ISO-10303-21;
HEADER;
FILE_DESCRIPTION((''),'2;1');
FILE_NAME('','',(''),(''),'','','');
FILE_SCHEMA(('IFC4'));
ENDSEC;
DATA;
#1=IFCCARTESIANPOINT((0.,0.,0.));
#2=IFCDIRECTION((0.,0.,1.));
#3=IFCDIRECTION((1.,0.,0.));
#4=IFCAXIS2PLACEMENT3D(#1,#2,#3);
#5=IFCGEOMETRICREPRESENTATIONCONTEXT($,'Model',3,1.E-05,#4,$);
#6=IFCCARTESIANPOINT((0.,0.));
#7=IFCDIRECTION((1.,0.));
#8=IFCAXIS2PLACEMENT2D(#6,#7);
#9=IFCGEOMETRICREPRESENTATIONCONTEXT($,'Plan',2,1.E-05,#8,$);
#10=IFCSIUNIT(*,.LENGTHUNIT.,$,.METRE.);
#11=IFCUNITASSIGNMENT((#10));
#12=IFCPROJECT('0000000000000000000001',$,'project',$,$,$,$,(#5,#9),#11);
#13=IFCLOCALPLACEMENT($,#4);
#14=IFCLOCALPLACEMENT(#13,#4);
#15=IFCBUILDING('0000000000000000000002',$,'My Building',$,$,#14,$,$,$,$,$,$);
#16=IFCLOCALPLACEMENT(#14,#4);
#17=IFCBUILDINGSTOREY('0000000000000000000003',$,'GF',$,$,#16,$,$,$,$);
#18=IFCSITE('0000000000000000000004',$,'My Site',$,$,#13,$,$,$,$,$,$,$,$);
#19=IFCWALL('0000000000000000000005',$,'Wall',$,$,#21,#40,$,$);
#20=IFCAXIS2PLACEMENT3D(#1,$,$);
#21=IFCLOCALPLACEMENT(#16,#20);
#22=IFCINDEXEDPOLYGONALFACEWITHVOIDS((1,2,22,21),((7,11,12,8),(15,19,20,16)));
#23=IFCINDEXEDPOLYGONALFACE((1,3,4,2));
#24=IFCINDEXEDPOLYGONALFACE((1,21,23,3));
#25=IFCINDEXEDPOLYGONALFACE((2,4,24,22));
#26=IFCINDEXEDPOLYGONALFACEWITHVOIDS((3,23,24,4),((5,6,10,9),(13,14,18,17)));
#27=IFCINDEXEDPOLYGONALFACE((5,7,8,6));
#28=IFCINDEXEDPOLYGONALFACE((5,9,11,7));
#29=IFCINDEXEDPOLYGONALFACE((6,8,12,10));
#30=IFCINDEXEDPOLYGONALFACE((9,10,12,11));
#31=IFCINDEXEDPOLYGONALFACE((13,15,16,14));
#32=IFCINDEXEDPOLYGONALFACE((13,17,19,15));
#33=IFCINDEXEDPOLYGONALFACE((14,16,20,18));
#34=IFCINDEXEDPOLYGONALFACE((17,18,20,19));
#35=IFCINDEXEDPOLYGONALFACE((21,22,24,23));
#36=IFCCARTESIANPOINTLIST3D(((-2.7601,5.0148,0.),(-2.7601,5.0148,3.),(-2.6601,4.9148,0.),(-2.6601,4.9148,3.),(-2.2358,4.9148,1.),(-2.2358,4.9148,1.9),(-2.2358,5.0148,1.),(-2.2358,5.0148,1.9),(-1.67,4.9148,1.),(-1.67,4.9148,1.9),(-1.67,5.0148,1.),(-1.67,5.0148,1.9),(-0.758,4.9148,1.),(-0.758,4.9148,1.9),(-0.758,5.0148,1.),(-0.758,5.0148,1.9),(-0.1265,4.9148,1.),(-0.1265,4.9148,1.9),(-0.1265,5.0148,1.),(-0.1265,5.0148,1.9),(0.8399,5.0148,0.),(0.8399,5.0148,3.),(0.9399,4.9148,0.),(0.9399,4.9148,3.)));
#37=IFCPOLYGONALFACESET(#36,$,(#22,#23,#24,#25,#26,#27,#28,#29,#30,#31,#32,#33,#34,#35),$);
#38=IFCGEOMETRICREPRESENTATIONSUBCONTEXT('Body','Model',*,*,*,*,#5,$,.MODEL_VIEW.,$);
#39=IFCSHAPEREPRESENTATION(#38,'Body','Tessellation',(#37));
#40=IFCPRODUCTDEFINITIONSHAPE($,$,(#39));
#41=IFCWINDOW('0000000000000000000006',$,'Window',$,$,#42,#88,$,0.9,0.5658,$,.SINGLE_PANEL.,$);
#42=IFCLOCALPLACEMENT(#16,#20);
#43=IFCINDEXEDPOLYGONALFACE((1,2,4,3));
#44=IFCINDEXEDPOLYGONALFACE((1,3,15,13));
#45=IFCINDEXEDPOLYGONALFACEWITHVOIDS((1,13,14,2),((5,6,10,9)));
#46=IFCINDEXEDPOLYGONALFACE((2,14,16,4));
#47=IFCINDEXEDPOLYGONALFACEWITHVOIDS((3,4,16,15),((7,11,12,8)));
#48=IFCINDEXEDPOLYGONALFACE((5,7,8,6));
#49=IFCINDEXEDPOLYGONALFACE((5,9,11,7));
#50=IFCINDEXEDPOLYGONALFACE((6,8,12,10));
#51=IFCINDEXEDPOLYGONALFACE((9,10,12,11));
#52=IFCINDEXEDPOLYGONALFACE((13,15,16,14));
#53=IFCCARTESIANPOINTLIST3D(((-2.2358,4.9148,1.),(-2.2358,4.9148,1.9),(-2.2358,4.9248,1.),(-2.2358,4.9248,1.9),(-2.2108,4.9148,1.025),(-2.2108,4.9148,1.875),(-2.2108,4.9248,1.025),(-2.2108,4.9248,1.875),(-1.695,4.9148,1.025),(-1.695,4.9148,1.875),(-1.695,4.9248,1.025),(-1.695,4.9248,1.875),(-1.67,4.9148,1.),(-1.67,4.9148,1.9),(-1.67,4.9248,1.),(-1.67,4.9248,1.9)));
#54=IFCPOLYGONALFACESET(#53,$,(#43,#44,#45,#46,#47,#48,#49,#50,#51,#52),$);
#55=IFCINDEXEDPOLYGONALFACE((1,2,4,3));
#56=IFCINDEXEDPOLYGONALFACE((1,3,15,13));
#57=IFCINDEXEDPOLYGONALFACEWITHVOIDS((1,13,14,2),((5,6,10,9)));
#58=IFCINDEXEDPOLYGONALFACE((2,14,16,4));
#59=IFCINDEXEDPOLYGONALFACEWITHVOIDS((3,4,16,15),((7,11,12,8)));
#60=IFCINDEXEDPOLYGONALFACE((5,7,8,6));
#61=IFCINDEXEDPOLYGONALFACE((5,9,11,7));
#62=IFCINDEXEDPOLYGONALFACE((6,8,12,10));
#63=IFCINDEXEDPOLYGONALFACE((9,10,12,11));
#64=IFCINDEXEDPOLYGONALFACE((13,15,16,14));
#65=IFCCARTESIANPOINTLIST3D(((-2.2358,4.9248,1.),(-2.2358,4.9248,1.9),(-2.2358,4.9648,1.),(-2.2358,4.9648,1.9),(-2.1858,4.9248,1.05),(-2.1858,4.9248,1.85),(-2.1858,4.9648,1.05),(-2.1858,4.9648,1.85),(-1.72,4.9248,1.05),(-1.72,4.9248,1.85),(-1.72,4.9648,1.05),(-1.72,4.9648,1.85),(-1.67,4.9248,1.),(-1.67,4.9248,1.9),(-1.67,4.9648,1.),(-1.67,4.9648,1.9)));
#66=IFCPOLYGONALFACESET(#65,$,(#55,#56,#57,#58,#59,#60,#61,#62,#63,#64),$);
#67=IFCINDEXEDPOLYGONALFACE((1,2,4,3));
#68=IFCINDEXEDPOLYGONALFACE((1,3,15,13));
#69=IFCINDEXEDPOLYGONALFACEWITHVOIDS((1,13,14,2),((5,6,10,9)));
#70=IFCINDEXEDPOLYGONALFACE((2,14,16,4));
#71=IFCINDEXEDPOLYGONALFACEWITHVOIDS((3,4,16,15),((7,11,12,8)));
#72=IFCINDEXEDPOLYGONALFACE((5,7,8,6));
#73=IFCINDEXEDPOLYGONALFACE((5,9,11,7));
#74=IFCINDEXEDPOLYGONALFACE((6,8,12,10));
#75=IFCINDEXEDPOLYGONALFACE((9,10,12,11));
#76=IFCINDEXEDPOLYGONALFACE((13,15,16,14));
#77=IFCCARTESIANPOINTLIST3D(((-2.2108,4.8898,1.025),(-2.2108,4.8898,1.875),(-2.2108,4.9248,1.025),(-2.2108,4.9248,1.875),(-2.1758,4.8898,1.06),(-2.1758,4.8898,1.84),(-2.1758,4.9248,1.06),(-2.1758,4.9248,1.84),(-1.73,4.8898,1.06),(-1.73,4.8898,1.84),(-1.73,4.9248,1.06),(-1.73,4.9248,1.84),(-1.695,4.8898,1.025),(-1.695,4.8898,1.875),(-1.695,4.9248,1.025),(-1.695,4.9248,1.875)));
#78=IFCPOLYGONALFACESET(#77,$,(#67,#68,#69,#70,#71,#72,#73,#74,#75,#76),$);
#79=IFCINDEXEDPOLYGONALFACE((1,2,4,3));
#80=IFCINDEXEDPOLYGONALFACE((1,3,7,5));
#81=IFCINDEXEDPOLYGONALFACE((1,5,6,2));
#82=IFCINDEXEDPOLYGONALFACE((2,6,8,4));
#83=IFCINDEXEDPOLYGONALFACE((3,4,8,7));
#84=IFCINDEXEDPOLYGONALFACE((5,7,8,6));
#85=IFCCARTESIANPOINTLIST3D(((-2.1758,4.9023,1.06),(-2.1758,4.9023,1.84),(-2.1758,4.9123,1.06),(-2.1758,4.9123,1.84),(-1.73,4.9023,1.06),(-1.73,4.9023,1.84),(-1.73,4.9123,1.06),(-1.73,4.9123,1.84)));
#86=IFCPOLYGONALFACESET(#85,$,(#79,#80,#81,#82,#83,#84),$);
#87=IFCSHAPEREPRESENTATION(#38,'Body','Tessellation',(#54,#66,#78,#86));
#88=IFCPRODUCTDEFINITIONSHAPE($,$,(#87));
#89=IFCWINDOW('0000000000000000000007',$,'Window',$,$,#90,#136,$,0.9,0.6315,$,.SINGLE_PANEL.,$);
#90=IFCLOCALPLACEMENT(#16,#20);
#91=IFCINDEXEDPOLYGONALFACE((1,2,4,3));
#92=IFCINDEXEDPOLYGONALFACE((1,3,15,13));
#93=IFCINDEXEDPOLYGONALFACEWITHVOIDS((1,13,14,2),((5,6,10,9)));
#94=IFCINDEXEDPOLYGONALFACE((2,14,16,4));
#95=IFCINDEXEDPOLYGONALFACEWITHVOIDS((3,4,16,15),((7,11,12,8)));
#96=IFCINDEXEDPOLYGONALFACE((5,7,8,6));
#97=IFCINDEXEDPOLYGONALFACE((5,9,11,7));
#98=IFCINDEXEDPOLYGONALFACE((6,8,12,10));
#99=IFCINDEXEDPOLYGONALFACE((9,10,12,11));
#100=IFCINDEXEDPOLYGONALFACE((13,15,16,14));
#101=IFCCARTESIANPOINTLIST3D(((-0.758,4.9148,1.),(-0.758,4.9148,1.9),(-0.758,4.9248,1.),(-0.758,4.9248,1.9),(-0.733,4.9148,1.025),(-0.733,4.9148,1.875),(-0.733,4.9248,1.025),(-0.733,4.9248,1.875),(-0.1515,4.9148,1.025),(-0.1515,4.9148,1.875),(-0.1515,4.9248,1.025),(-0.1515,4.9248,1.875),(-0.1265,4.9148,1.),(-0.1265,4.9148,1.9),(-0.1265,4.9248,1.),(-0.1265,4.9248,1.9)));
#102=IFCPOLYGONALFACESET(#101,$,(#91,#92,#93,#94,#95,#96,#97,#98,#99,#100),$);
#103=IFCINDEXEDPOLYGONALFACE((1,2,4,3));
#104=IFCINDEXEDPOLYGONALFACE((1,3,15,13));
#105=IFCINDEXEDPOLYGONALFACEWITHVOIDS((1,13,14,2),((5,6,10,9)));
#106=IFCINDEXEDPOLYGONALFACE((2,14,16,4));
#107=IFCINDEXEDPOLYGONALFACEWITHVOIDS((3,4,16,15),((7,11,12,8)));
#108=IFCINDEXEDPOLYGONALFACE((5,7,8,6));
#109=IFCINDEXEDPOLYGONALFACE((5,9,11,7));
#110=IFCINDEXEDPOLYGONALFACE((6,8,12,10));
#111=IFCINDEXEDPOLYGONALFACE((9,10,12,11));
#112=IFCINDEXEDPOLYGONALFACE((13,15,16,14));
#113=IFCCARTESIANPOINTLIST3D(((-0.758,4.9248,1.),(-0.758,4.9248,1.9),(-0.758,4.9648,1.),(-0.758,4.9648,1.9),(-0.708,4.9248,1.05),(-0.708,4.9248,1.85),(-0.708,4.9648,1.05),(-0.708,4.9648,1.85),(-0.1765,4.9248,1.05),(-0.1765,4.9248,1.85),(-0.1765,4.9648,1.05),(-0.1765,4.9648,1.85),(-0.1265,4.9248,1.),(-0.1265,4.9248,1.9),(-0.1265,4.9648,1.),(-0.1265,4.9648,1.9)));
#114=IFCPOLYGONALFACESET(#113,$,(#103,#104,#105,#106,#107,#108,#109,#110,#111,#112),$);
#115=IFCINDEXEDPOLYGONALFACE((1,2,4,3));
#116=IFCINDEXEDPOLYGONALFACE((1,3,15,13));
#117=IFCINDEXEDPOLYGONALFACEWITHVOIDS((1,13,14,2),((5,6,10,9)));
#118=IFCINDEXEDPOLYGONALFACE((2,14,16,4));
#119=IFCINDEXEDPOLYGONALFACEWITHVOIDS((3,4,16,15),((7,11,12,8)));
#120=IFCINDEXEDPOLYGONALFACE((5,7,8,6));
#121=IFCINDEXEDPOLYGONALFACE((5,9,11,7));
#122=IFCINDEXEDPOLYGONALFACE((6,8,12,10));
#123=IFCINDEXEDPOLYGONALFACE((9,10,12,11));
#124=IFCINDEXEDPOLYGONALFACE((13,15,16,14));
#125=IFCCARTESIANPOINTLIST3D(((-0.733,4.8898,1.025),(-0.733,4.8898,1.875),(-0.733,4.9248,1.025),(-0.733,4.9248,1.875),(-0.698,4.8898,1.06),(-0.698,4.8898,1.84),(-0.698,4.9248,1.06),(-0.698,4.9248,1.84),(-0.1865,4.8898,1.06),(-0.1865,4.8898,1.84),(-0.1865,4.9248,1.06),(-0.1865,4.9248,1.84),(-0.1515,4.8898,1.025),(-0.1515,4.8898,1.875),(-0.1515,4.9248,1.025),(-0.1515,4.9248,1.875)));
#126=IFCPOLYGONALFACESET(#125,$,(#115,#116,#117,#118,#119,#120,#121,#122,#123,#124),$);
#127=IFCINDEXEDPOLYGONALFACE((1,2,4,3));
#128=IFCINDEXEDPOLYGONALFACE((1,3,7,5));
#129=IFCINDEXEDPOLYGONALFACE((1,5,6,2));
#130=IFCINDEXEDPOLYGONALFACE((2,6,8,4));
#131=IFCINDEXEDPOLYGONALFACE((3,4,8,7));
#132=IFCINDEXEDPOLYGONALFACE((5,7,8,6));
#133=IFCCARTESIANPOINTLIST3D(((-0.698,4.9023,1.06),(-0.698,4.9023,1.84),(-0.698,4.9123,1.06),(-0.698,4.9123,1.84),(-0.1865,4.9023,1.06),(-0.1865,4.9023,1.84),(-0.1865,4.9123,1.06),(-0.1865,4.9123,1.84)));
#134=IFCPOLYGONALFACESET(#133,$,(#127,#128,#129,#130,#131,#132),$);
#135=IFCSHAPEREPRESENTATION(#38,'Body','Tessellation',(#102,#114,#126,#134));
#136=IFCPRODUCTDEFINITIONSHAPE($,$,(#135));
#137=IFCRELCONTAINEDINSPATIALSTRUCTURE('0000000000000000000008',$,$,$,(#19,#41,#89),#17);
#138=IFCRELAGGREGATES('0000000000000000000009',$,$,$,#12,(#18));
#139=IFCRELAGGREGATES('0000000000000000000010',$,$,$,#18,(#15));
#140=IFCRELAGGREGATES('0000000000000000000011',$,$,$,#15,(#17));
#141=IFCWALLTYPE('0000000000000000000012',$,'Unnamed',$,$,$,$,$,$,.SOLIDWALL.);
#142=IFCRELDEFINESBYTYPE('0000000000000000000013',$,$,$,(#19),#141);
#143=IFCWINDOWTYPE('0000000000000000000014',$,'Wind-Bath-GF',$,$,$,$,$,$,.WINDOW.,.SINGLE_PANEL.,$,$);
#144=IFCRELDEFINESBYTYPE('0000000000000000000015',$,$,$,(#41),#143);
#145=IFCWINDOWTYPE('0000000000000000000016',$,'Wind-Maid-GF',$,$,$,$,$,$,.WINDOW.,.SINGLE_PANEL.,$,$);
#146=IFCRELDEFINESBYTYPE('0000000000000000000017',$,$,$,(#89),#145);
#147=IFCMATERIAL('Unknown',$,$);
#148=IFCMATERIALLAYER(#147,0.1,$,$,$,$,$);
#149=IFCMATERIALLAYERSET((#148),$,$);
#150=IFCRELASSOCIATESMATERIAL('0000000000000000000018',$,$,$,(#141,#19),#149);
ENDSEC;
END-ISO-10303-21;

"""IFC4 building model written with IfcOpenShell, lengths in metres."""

from ifc_helpers import new_model, entity, si_unit, frame, origin_with_axes, origin_2d_with_axis, place, context, subcontext, project, spatial, line, indexed_curve, outline, extrude, shape, source, transform, mapped, material, layer, layer_set, layer_usage, type_object, type_shapes, element, fill, save


model = new_model("IFC4")

# Units and contexts
model_context = context("Model", 3, precision=1e-05, world=origin_with_axes())
plan_context = context("Plan", 2, precision=1e-05, world=origin_2d_with_axis())
body_context_1 = subcontext(model_context, "Body", "Model", "MODEL_VIEW")
body_context_2 = subcontext(plan_context, "Body", "Plan", "PLAN_VIEW")
ifc_project = project(units=[si_unit("LENGTHUNIT", "METRE")], contexts=[model_context, plan_context])

# Site, building, storey
site_placement = place(None, origin_with_axes())
site = spatial("IfcSite", under=ifc_project, at=site_placement, Name="My Site")
building_placement = place(site_placement, origin_with_axes())
building = spatial("IfcBuilding", under=site, at=building_placement, Name="My Building")
storey_placement = place(building_placement, origin_with_axes())
storey = spatial("IfcBuildingStorey", under=building, at=storey_placement, Name="GF")

# Shared definitions
ifc_material = material(Name="Unknown")

# Shared definitions
ifc_layer_1 = layer(ifc_material, 0.1)
ifc_layer_set_1 = layer_set([ifc_layer_1])
wall_type = type_object("IfcWallType", Name="Unnamed", PredefinedType="SOLIDWALL", material=ifc_layer_set_1)

# Wall, openings, windows
ifc_layer_usage_1 = layer_usage(ifc_layer_set_1, "AXIS2", "POSITIVE", 0.0)
wall_1_placement = place(storey_placement, frame((0.8399, 5.0148, 0.0), z_axis=(0.0, 0.0, 1.0), x_axis=(-1.0, 0.0, 0.0)))
wall_1 = element("IfcWall", 1, at=wall_1_placement, inside=storey, type_object=wall_type, material=ifc_layer_usage_1, Name="Wall", context=body_context_1, shape_type="SweptSolid", body=[
    extrude(outline(indexed_curve([(0.0, 0.0), (-0.1, 0.1), (3.5, 0.1), (3.6, 0.0)], segments=[line(1, 2, 3, 4, 1)])), origin_with_axes(), (0.0, 0.0, 1.0), 3.0),
])
shared_shape_1 = source(origin_with_axes(), body_context_1, "Body", "SweptSolid", [
    extrude(outline(indexed_curve([(0.0, 0.0), (0.5658, 0.0), (0.5658, 0.9), (0.0, 0.9)], segments=[line(1, 2, 3, 4, 1)])), frame((0.0, -0.6, 0.0), z_axis=(0.0, -1.0, 0.0), x_axis=(1.0, 0.0, 0.0)), (0.0, 0.0, -1.0), 1.2),
])
opening_1_placement = place(wall_1_placement, frame((2.5099, 0.0, 1.0), z_axis=(0.0, 0.0, 1.0), x_axis=(1.0, 0.0, 0.0)))
opening_1 = element("IfcOpeningElement", 2, at=opening_1_placement, cuts=wall_1, PredefinedType="OPENING", context=body_context_1, shape_type="MappedRepresentation", body=[
    mapped(shared_shape_1, transform((0.0, 0.0, 0.0), x_axis=(1.0, 0.0, 0.0), y_axis=(0.0, 1.0, 0.0), z_axis=(0.0, 0.0, 1.0), scale=1.0)),
])
shared_shape_2 = source(origin_with_axes(), body_context_1, "Body", "SweptSolid", [
    extrude(outline(indexed_curve([(0.0, 0.0), (0.6315, 0.0), (0.6315, 0.9), (0.0, 0.9)], segments=[line(1, 2, 3, 4, 1)])), frame((0.0, -0.6, 0.0), z_axis=(0.0, -1.0, 0.0), x_axis=(1.0, 0.0, 0.0)), (0.0, 0.0, -1.0), 1.2),
])
opening_2_placement = place(wall_1_placement, frame((0.9664, 0.0, 1.0), z_axis=(0.0, 0.0, 1.0), x_axis=(1.0, 0.0, 0.0)))
opening_2 = element("IfcOpeningElement", 3, at=opening_2_placement, cuts=wall_1, PredefinedType="OPENING", context=body_context_1, shape_type="MappedRepresentation", body=[
    mapped(shared_shape_2, transform((0.0, 0.0, 0.0), x_axis=(1.0, 0.0, 0.0), y_axis=(0.0, 1.0, 0.0), z_axis=(0.0, 0.0, 1.0), scale=1.0)),
])
window_type_1 = type_object("IfcWindowType", Name="Wind-Bath-GF", PartitioningType="SINGLE_PANEL", PredefinedType="WINDOW")
shared_shape_3 = source(origin_with_axes(), body_context_1, "Body", "SweptSolid", [
    extrude(outline(indexed_curve([(0.0, 0.0), (0.5658, 0.0), (0.5658, 0.9), (0.0, 0.9)], segments=[line(1, 2, 3, 4, 1)]), holes=[indexed_curve([(0.025, 0.025), (0.5408, 0.025), (0.5408, 0.875), (0.025, 0.875)], segments=[line(1, 2, 3, 4, 1)])]), frame((0.0, 0.09, 0.0), z_axis=(0.0, -1.0, 0.0), x_axis=(1.0, 0.0, 0.0)), (0.0, 0.0, -1.0), 0.01),
    extrude(outline(indexed_curve([(0.0, 0.0), (0.5658, 0.0), (0.5658, 0.9), (0.0, 0.9)], segments=[line(1, 2, 3, 4, 1)]), holes=[indexed_curve([(0.05, 0.05), (0.5158, 0.05), (0.5158, 0.85), (0.05, 0.85)], segments=[line(1, 2, 3, 4, 1)])]), frame((0.0, 0.05, 0.0), z_axis=(0.0, -1.0, 0.0), x_axis=(1.0, 0.0, 0.0)), (0.0, 0.0, -1.0), 0.04),
    extrude(outline(indexed_curve([(0.0, 0.0), (0.5158, 0.0), (0.5158, 0.85), (0.0, 0.85)], segments=[line(1, 2, 3, 4, 1)]), holes=[indexed_curve([(0.035, 0.035), (0.4808, 0.035), (0.4808, 0.815), (0.035, 0.815)], segments=[line(1, 2, 3, 4, 1)])]), frame((0.025, 0.09, 0.025), z_axis=(0.0, -1.0, 0.0), x_axis=(1.0, 0.0, 0.0)), (0.0, 0.0, -1.0), 0.035),
    extrude(outline(indexed_curve([(0.035, 0.035), (0.4808, 0.035), (0.4808, 0.815), (0.035, 0.815)], segments=[line(1, 2, 3, 4, 1)])), frame((0.025, 0.1025, 0.025), z_axis=(0.0, -1.0, 0.0), x_axis=(1.0, 0.0, 0.0)), (0.0, 0.0, -1.0), 0.01),
])
shared_shape_4 = source(origin_with_axes(), body_context_2, "Body", "Curve2D", [
    entity("IfcIndexedPolyCurve", entity("IfcCartesianPointList2D", [[0.05, 0.05], [0.5158, 0.05]])),
    entity("IfcIndexedPolyCurve", entity("IfcCartesianPointList2D", [[0.0, 0.1], [0.025, 0.1], [0.025, 0.09], [0.05, 0.09], [0.05, 0.05], [0.0, 0.05]]), [entity("IfcLineIndex", [1, 2, 3, 4, 5, 6, 1])]),
    entity("IfcIndexedPolyCurve", entity("IfcCartesianPointList2D", [[0.5658, 0.1], [0.5408, 0.1], [0.5408, 0.09], [0.5158, 0.09], [0.5158, 0.05], [0.5658, 0.05]]), [entity("IfcLineIndex", [1, 2, 3, 4, 5, 6, 1])]),
    entity("IfcIndexedPolyCurve", entity("IfcCartesianPointList2D", [[0.025, 0.09], [0.06, 0.09], [0.06, 0.125], [0.025, 0.125]]), [entity("IfcLineIndex", [1, 2, 3, 4, 1])]),
    entity("IfcIndexedPolyCurve", entity("IfcCartesianPointList2D", [[0.5408, 0.09], [0.5058, 0.09], [0.5058, 0.125], [0.5408, 0.125]]), [entity("IfcLineIndex", [1, 2, 3, 4, 1])]),
    entity("IfcIndexedPolyCurve", entity("IfcCartesianPointList2D", [[0.06, 0.09], [0.5058, 0.09]])),
    entity("IfcIndexedPolyCurve", entity("IfcCartesianPointList2D", [[0.06, 0.125], [0.5058, 0.125]])),
    entity("IfcIndexedPolyCurve", entity("IfcCartesianPointList2D", [[0.06, 0.1075], [0.5058, 0.1075]])),
])
type_shapes(window_type_1, [shared_shape_3, shared_shape_4])
window_1_placement = place(opening_1_placement, frame((0.0, 0.0, 0.0), z_axis=(0.0, 0.0, 1.0), x_axis=(1.0, 0.0, 0.0)))
window_1 = element("IfcWindow", 4, at=window_1_placement, inside=storey, type_object=window_type_1, Name="Window", OverallHeight=0.9, OverallWidth=0.5658, PartitioningType="SINGLE_PANEL", shapes=[
    shape(body_context_1, "Body", "MappedRepresentation", [mapped(shared_shape_3, transform((0.0, 0.0, 0.0), x_axis=(1.0, 0.0, 0.0), y_axis=(0.0, 1.0, 0.0), z_axis=(0.0, 0.0, 1.0), scale=1.0))]),
    shape(body_context_2, "Body", "MappedRepresentation", [mapped(shared_shape_4, transform((0.0, 0.0, 0.0), x_axis=(1.0, 0.0, 0.0), y_axis=(0.0, 1.0, 0.0), z_axis=(0.0, 0.0, 1.0), scale=1.0))]),
])
fill(opening_1, window_1)
window_type_2 = type_object("IfcWindowType", Name="Wind-Maid-GF", PartitioningType="SINGLE_PANEL", PredefinedType="WINDOW")
shared_shape_5 = source(origin_with_axes(), body_context_1, "Body", "SweptSolid", [
    extrude(outline(indexed_curve([(0.0, 0.0), (0.6315, 0.0), (0.6315, 0.9), (0.0, 0.9)], segments=[line(1, 2, 3, 4, 1)]), holes=[indexed_curve([(0.025, 0.025), (0.6065, 0.025), (0.6065, 0.875), (0.025, 0.875)], segments=[line(1, 2, 3, 4, 1)])]), frame((0.0, 0.09, 0.0), z_axis=(0.0, -1.0, 0.0), x_axis=(1.0, 0.0, 0.0)), (0.0, 0.0, -1.0), 0.01),
    extrude(outline(indexed_curve([(0.0, 0.0), (0.6315, 0.0), (0.6315, 0.9), (0.0, 0.9)], segments=[line(1, 2, 3, 4, 1)]), holes=[indexed_curve([(0.05, 0.05), (0.5815, 0.05), (0.5815, 0.85), (0.05, 0.85)], segments=[line(1, 2, 3, 4, 1)])]), frame((0.0, 0.05, 0.0), z_axis=(0.0, -1.0, 0.0), x_axis=(1.0, 0.0, 0.0)), (0.0, 0.0, -1.0), 0.04),
    extrude(outline(indexed_curve([(0.0, 0.0), (0.5815, 0.0), (0.5815, 0.85), (0.0, 0.85)], segments=[line(1, 2, 3, 4, 1)]), holes=[indexed_curve([(0.035, 0.035), (0.5465, 0.035), (0.5465, 0.815), (0.035, 0.815)], segments=[line(1, 2, 3, 4, 1)])]), frame((0.025, 0.09, 0.025), z_axis=(0.0, -1.0, 0.0), x_axis=(1.0, 0.0, 0.0)), (0.0, 0.0, -1.0), 0.035),
    extrude(outline(indexed_curve([(0.035, 0.035), (0.5465, 0.035), (0.5465, 0.815), (0.035, 0.815)], segments=[line(1, 2, 3, 4, 1)])), frame((0.025, 0.1025, 0.025), z_axis=(0.0, -1.0, 0.0), x_axis=(1.0, 0.0, 0.0)), (0.0, 0.0, -1.0), 0.01),
])
shared_shape_6 = source(origin_with_axes(), body_context_2, "Body", "Curve2D", [
    entity("IfcIndexedPolyCurve", entity("IfcCartesianPointList2D", [[0.05, 0.05], [0.5815, 0.05]])),
    entity("IfcIndexedPolyCurve", entity("IfcCartesianPointList2D", [[0.0, 0.1], [0.025, 0.1], [0.025, 0.09], [0.05, 0.09], [0.05, 0.05], [0.0, 0.05]]), [entity("IfcLineIndex", [1, 2, 3, 4, 5, 6, 1])]),
    entity("IfcIndexedPolyCurve", entity("IfcCartesianPointList2D", [[0.6315, 0.1], [0.6065, 0.1], [0.6065, 0.09], [0.5815, 0.09], [0.5815, 0.05], [0.6315, 0.05]]), [entity("IfcLineIndex", [1, 2, 3, 4, 5, 6, 1])]),
    entity("IfcIndexedPolyCurve", entity("IfcCartesianPointList2D", [[0.025, 0.09], [0.06, 0.09], [0.06, 0.125], [0.025, 0.125]]), [entity("IfcLineIndex", [1, 2, 3, 4, 1])]),
    entity("IfcIndexedPolyCurve", entity("IfcCartesianPointList2D", [[0.6065, 0.09], [0.5715, 0.09], [0.5715, 0.125], [0.6065, 0.125]]), [entity("IfcLineIndex", [1, 2, 3, 4, 1])]),
    entity("IfcIndexedPolyCurve", entity("IfcCartesianPointList2D", [[0.06, 0.09], [0.5715, 0.09]])),
    entity("IfcIndexedPolyCurve", entity("IfcCartesianPointList2D", [[0.06, 0.125], [0.5715, 0.125]])),
    entity("IfcIndexedPolyCurve", entity("IfcCartesianPointList2D", [[0.06, 0.1075], [0.5715, 0.1075]])),
])
type_shapes(window_type_2, [shared_shape_5, shared_shape_6])
window_2_placement = place(opening_2_placement, frame((0.0, 0.0, 0.0), z_axis=(0.0, 0.0, 1.0), x_axis=(1.0, 0.0, 0.0)))
window_2 = element("IfcWindow", 5, at=window_2_placement, inside=storey, type_object=window_type_2, Name="Window", OverallHeight=0.9, OverallWidth=0.6315, PartitioningType="SINGLE_PANEL", shapes=[
    shape(body_context_1, "Body", "MappedRepresentation", [mapped(shared_shape_5, transform((0.0, 0.0, 0.0), x_axis=(1.0, 0.0, 0.0), y_axis=(0.0, 1.0, 0.0), z_axis=(0.0, 0.0, 1.0), scale=1.0))]),
    shape(body_context_2, "Body", "MappedRepresentation", [mapped(shared_shape_6, transform((0.0, 0.0, 0.0), x_axis=(1.0, 0.0, 0.0), y_axis=(0.0, 1.0, 0.0), z_axis=(0.0, 0.0, 1.0), scale=1.0))]),
])
fill(opening_2, window_2)

save(model, "model.ifc")
